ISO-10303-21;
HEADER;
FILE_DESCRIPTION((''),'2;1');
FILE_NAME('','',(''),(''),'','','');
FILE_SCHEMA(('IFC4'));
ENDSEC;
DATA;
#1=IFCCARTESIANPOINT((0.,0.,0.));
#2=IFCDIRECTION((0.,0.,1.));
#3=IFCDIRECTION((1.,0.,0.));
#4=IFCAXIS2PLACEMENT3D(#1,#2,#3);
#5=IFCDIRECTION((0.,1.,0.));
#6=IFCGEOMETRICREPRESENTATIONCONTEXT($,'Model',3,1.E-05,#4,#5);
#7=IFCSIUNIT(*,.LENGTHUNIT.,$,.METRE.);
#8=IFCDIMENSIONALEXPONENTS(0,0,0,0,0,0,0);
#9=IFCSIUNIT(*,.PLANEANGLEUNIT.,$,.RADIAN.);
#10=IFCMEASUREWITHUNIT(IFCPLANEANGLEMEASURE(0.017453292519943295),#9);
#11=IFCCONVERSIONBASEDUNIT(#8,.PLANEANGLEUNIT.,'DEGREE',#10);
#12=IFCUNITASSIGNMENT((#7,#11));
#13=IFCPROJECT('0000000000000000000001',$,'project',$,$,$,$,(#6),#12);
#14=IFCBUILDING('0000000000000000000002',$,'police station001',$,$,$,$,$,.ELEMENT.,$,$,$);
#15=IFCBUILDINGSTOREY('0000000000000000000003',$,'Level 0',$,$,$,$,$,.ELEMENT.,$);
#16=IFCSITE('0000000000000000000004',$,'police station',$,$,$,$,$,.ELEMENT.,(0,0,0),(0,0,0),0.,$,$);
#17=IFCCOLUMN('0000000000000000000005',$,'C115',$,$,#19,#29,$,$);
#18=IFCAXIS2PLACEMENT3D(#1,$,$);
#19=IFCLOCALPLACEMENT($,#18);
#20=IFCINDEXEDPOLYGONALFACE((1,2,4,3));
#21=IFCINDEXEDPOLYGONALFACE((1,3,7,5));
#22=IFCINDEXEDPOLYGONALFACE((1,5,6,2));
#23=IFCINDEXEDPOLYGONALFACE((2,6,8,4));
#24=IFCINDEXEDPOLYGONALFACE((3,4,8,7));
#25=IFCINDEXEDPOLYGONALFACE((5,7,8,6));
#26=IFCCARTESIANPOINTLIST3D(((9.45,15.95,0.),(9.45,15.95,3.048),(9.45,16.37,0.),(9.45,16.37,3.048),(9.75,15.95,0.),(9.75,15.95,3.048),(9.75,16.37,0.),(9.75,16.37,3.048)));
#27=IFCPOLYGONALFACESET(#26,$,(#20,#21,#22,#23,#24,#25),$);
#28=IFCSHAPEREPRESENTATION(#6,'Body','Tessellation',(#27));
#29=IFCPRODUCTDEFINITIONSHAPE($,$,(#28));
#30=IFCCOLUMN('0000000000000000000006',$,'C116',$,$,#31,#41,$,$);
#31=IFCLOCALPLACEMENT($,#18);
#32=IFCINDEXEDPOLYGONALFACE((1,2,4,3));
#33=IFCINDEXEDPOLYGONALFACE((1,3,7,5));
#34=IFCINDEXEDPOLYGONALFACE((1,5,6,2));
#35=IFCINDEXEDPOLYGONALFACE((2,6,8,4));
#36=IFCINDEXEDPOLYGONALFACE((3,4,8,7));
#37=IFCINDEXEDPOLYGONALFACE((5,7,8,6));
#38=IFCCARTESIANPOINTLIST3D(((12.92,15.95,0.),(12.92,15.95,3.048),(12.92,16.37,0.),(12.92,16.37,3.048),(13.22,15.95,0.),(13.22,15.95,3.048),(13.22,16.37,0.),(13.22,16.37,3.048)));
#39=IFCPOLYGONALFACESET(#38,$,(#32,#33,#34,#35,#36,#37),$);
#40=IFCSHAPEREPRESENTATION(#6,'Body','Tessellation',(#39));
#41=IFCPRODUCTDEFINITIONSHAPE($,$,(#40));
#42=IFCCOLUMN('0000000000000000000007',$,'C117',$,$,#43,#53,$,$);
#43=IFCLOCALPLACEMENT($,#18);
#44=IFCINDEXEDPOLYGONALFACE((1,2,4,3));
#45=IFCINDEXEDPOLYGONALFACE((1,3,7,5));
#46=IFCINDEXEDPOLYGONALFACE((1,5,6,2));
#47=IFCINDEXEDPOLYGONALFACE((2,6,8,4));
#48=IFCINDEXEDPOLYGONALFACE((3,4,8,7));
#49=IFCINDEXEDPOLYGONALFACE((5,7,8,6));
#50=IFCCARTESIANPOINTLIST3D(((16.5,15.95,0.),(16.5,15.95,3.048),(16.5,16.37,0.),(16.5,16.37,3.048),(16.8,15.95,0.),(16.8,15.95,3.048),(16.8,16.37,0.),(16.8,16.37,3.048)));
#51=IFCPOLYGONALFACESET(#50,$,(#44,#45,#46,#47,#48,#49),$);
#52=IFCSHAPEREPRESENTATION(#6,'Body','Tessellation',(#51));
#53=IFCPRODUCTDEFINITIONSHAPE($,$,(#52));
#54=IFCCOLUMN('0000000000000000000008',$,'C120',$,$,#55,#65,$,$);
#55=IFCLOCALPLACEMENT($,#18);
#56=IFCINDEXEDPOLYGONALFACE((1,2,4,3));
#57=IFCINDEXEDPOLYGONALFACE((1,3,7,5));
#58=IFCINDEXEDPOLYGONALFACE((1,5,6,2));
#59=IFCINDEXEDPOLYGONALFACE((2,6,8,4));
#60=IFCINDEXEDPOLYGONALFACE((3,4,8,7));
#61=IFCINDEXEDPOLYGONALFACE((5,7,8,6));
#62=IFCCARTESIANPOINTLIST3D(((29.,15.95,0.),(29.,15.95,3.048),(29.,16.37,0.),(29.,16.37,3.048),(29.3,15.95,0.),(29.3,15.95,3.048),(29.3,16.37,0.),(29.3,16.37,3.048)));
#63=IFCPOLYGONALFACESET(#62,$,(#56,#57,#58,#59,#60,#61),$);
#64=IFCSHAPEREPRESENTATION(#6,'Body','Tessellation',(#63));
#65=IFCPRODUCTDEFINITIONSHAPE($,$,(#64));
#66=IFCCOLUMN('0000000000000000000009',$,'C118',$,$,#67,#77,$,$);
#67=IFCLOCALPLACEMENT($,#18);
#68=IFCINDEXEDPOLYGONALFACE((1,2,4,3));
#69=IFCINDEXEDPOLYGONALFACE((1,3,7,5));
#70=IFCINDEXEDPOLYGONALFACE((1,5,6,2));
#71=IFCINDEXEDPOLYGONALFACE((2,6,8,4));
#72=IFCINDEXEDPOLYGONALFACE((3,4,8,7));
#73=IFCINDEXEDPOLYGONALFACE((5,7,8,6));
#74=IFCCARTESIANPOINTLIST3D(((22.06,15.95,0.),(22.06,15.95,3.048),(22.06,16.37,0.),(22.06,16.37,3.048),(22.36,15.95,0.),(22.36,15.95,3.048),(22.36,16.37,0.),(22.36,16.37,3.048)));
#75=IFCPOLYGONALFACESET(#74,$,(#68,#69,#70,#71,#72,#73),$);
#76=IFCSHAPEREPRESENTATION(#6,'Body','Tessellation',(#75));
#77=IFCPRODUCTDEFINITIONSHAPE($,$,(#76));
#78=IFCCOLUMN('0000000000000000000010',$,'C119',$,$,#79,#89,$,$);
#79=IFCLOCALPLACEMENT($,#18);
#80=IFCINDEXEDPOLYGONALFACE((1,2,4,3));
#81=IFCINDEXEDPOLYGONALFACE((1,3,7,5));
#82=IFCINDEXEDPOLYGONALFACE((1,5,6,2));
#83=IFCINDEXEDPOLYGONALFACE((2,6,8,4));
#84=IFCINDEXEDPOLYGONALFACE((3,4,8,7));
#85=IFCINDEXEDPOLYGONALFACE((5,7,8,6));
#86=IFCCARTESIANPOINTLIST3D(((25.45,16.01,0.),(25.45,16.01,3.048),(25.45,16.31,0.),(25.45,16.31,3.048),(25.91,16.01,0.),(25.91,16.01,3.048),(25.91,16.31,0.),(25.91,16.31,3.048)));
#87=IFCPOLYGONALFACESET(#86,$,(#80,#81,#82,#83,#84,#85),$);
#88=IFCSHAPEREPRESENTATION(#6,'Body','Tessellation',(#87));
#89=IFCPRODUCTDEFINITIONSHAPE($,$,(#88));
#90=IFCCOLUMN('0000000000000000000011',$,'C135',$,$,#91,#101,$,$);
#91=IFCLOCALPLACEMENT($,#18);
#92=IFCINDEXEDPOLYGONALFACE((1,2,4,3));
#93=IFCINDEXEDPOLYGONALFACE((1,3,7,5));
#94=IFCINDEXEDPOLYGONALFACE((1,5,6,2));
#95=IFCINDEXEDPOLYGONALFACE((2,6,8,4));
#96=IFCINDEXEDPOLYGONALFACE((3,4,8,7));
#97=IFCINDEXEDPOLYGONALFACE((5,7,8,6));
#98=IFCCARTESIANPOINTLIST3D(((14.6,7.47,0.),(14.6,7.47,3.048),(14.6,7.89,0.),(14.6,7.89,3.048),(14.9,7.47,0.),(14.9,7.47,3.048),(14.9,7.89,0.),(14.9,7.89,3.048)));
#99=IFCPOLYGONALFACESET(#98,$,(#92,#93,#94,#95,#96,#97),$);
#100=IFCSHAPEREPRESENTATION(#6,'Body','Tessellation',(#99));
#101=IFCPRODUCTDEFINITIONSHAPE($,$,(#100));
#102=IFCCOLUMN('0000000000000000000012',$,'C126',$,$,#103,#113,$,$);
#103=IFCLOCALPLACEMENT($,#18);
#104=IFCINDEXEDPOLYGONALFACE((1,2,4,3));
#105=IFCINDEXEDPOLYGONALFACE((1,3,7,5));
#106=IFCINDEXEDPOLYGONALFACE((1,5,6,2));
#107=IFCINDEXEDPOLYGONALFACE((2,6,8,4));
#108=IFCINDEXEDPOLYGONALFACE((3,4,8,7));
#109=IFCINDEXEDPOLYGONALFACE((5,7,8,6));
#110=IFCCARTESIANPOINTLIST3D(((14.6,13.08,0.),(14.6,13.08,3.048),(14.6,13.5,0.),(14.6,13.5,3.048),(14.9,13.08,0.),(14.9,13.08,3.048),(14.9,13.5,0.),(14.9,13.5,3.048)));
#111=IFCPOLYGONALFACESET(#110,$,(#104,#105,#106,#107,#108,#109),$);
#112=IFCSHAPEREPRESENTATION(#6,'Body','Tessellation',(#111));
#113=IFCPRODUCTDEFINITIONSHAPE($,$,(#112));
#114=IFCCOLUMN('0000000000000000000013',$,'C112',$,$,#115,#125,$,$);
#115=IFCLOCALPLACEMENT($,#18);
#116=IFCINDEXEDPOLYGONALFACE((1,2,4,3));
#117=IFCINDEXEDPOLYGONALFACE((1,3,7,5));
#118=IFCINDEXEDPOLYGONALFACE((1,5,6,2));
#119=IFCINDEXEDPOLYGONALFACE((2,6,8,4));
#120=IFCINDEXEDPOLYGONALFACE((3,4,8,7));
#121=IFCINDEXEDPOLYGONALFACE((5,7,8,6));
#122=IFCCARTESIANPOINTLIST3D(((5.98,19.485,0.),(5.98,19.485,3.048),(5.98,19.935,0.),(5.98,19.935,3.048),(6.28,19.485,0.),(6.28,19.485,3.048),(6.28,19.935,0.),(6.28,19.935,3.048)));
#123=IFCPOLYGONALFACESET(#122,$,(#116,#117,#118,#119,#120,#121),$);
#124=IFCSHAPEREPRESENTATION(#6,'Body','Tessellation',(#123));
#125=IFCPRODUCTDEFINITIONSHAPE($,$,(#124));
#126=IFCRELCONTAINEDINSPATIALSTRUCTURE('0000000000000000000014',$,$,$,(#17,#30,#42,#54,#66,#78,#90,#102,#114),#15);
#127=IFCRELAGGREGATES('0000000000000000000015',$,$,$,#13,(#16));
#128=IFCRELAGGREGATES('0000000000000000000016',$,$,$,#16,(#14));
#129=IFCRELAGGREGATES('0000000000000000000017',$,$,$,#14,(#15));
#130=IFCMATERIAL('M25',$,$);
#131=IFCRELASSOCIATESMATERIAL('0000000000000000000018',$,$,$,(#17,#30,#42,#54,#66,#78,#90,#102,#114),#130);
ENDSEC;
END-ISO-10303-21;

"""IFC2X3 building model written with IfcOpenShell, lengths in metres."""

from ifc_helpers import new_model, entity, si_unit, converted_unit, direction, frame, frame_2d, origin_with_axes, place, context, project, spatial, rectangle, extrude, material, element, save


model = new_model("IFC2X3")

# Units and contexts
model_context = context("Model", 3, precision=1e-05, world=origin_with_axes(), true_north=direction((0.0, 1.0, 0.0)))
ifc_project = project(units=[si_unit("LENGTHUNIT", "METRE"), converted_unit("PLANEANGLEUNIT", "DEGREE", entity("IfcPlaneAngleMeasure", 0.017453292519943295), si_unit("PLANEANGLEUNIT", "RADIAN"), dimensions=[0, 0, 0, 0, 0, 0, 0])], contexts=[model_context])

# Site, building, storey
site = spatial("IfcSite", under=ifc_project, Name="police station", CompositionType="ELEMENT", RefLatitude=(0, 0, 0), RefLongitude=(0, 0, 0), RefElevation=0.0)
building = spatial("IfcBuilding", under=site, Name="police station001", CompositionType="ELEMENT")
storey = spatial("IfcBuildingStorey", under=building, Name="Level 0", CompositionType="ELEMENT")

# Columns
ifc_material = material(Name="M25")
placement = place(None, origin_with_axes())
element("IfcColumn", 1, at=placement, inside=storey, material=ifc_material, Name="C115", context=model_context, shape_type="SweptSolid", body=[
    extrude(rectangle(XDim=0.3, YDim=0.42, at=frame_2d((0.0, 0.0), x_axis=(1.0, 0.0, 0.0))), frame((9.6, 16.16, 0.0), z_axis=(0.0, 0.0, 1.0), x_axis=(1.0, 0.0, 0.0)), (0.0, 0.0, 1.0), 3.048),
])
element("IfcColumn", 2, at=placement, inside=storey, material=ifc_material, Name="C116", context=model_context, shape_type="SweptSolid", body=[
    extrude(rectangle(XDim=0.3, YDim=0.42, at=frame_2d((0.0, 0.0), x_axis=(1.0, 0.0, 0.0))), frame((13.07, 16.16, 0.0), z_axis=(0.0, 0.0, 1.0), x_axis=(1.0, 0.0, 0.0)), (0.0, 0.0, 1.0), 3.048),
])
element("IfcColumn", 3, at=placement, inside=storey, material=ifc_material, Name="C117", context=model_context, shape_type="SweptSolid", body=[
    extrude(rectangle(XDim=0.3, YDim=0.42, at=frame_2d((0.0, 0.0), x_axis=(1.0, 0.0, 0.0))), frame((16.65, 16.16, 0.0), z_axis=(0.0, 0.0, 1.0), x_axis=(1.0, 0.0, 0.0)), (0.0, 0.0, 1.0), 3.048),
])
element("IfcColumn", 4, at=placement, inside=storey, material=ifc_material, Name="C120", context=model_context, shape_type="SweptSolid", body=[
    extrude(rectangle(XDim=0.3, YDim=0.42, at=frame_2d((0.0, 0.0), x_axis=(1.0, 0.0, 0.0))), frame((29.15, 16.16, 0.0), z_axis=(0.0, 0.0, 1.0), x_axis=(1.0, 0.0, 0.0)), (0.0, 0.0, 1.0), 3.048),
])
element("IfcColumn", 5, at=placement, inside=storey, material=ifc_material, Name="C118", context=model_context, shape_type="SweptSolid", body=[
    extrude(rectangle(XDim=0.3, YDim=0.42, at=frame_2d((0.0, 0.0), x_axis=(1.0, 0.0, 0.0))), frame((22.21, 16.16, 0.0), z_axis=(0.0, 0.0, 1.0), x_axis=(1.0, 0.0, 0.0)), (0.0, 0.0, 1.0), 3.048),
])
element("IfcColumn", 6, at=placement, inside=storey, material=ifc_material, Name="C119", context=model_context, shape_type="SweptSolid", body=[
    extrude(rectangle(XDim=0.46, YDim=0.3, at=frame_2d((0.0, 0.0), x_axis=(1.0, 0.0, 0.0))), frame((25.68, 16.16, 0.0), z_axis=(0.0, 0.0, 1.0), x_axis=(1.0, 0.0, 0.0)), (0.0, 0.0, 1.0), 3.048),
])
element("IfcColumn", 7, at=placement, inside=storey, material=ifc_material, Name="C135", context=model_context, shape_type="SweptSolid", body=[
    extrude(rectangle(XDim=0.3, YDim=0.42, at=frame_2d((0.0, 0.0), x_axis=(1.0, 0.0, 0.0))), frame((14.75, 7.68, 0.0), z_axis=(0.0, 0.0, 1.0), x_axis=(1.0, 0.0, 0.0)), (0.0, 0.0, 1.0), 3.048),
])
element("IfcColumn", 8, at=placement, inside=storey, material=ifc_material, Name="C126", context=model_context, shape_type="SweptSolid", body=[
    extrude(rectangle(XDim=0.3, YDim=0.42, at=frame_2d((0.0, 0.0), x_axis=(1.0, 0.0, 0.0))), frame((14.75, 13.29, 0.0), z_axis=(0.0, 0.0, 1.0), x_axis=(1.0, 0.0, 0.0)), (0.0, 0.0, 1.0), 3.048),
])
element("IfcColumn", 9, at=placement, inside=storey, material=ifc_material, Name="C112", context=model_context, shape_type="SweptSolid", body=[
    extrude(rectangle(XDim=0.3, YDim=0.45, at=frame_2d((0.0, 0.0), x_axis=(1.0, 0.0, 0.0))), frame((6.13, 19.71, 0.0), z_axis=(0.0, 0.0, 1.0), x_axis=(1.0, 0.0, 0.0)), (0.0, 0.0, 1.0), 3.048),
])

save(model, "model.ifc")
